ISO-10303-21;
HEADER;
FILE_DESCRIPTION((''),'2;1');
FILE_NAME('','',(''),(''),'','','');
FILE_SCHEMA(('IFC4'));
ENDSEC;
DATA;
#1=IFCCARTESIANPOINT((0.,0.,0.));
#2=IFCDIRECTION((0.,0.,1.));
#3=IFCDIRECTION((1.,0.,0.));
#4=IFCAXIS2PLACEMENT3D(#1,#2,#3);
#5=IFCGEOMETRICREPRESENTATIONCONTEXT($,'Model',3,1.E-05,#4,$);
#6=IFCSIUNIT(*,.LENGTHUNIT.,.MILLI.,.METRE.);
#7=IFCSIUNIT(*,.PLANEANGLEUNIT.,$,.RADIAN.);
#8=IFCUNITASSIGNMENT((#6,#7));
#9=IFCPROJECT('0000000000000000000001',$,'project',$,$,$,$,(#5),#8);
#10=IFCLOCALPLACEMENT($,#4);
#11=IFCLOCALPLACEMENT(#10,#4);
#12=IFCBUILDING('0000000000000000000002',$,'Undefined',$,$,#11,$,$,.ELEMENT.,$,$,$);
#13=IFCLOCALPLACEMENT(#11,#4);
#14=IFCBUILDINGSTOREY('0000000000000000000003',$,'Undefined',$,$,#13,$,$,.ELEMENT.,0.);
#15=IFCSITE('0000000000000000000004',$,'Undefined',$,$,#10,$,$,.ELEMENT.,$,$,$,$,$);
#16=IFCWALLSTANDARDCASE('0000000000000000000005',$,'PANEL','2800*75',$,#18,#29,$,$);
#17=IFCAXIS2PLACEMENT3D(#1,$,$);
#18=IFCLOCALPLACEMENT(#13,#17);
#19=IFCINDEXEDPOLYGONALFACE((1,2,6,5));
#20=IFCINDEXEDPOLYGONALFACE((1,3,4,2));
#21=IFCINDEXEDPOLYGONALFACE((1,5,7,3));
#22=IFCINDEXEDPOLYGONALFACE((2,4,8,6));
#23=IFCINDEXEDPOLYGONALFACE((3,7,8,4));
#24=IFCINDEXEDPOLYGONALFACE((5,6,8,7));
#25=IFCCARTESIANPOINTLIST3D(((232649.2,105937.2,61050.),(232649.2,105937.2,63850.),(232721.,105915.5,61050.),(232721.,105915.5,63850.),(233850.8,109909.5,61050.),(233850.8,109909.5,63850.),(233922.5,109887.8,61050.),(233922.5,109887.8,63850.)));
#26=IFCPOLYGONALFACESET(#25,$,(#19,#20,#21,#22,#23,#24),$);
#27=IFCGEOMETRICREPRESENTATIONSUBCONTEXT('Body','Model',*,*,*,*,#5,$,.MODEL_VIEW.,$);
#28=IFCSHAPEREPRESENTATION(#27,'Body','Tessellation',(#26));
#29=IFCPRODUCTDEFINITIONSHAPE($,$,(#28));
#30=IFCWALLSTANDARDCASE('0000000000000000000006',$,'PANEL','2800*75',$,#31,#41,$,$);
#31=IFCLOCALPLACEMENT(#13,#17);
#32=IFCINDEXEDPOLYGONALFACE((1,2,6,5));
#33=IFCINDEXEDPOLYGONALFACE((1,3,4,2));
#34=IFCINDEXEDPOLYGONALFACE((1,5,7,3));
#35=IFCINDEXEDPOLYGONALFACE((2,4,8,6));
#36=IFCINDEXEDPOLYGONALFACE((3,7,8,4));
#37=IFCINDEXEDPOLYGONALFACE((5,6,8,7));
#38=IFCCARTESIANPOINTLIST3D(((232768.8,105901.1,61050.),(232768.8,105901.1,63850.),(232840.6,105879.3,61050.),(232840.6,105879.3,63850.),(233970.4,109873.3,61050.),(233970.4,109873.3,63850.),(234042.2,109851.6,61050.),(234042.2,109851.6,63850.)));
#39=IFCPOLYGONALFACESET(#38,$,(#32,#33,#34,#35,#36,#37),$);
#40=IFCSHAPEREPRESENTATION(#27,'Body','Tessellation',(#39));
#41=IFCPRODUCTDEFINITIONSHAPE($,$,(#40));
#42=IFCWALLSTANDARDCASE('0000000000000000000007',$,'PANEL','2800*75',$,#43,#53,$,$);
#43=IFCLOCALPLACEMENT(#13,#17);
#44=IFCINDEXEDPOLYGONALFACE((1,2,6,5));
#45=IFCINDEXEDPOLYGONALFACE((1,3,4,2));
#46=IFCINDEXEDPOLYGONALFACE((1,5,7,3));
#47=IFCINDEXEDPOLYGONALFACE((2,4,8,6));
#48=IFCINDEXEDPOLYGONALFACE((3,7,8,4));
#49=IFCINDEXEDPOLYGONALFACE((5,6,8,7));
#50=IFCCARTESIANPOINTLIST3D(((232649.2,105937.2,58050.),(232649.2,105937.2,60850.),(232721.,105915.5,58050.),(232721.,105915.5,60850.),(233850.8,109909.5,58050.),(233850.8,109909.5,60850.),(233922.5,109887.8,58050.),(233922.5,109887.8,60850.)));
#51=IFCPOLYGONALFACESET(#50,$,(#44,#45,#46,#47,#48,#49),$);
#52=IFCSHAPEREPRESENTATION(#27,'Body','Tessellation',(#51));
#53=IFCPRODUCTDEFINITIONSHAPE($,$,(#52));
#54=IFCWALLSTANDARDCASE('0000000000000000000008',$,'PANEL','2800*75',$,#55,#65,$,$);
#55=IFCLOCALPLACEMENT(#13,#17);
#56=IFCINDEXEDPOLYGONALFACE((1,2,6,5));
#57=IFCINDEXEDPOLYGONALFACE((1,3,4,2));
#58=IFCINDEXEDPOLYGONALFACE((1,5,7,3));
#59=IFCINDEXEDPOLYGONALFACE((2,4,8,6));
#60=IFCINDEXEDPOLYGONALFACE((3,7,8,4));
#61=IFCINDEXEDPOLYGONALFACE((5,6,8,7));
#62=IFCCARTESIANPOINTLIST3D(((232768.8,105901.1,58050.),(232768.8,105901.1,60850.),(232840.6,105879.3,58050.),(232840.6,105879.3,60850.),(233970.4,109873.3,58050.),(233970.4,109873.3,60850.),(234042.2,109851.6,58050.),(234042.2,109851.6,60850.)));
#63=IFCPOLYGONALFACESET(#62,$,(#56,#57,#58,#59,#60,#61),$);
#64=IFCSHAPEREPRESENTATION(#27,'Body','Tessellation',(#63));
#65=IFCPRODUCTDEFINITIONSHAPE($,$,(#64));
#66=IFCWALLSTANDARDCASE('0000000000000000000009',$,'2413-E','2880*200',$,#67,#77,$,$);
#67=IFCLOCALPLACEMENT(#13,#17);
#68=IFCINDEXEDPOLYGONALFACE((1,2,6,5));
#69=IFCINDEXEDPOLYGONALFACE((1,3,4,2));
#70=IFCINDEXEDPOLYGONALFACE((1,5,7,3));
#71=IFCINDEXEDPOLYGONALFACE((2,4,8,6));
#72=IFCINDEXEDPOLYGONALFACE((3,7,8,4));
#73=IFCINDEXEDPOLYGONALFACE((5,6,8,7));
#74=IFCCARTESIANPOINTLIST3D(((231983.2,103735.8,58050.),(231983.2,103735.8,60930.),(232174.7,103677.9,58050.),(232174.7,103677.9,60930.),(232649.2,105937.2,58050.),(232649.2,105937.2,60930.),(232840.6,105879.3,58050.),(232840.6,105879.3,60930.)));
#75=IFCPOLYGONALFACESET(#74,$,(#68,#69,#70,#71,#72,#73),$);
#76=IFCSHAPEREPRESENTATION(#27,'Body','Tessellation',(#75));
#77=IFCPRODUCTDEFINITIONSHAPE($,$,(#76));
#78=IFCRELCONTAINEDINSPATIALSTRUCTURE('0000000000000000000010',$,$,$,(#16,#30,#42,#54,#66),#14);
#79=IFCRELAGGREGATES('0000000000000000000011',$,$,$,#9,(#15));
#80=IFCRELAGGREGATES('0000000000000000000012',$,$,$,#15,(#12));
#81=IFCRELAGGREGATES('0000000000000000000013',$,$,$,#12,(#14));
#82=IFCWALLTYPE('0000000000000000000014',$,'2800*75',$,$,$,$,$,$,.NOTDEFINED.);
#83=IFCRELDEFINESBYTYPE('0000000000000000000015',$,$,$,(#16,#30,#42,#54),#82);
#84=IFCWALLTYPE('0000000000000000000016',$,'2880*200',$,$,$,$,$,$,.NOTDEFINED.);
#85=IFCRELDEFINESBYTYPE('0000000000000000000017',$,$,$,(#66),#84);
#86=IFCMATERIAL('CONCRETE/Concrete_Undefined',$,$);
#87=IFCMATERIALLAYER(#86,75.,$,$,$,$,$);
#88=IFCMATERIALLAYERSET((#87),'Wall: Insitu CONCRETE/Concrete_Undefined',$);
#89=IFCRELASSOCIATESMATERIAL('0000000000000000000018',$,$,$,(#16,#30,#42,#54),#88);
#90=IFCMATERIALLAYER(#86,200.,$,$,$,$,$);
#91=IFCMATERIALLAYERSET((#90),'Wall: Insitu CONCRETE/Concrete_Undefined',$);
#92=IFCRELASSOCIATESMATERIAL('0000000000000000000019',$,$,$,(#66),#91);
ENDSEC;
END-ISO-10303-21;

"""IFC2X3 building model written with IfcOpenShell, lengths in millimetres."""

from ifc_helpers import new_model, si_unit, frame, frame_2d, origin_with_axes, place, context, subcontext, project, spatial, rectangle, extrude, material, layer, layer_set, layer_usage, type_object, element, save


model = new_model("IFC2X3")

# Units and contexts
model_context = context("Model", 3, precision=1e-05, world=origin_with_axes())
body_context = subcontext(model_context, "Body", "Model", "MODEL_VIEW")
ifc_project = project(units=[si_unit("LENGTHUNIT", "METRE", prefix="MILLI"), si_unit("PLANEANGLEUNIT", "RADIAN")], contexts=[model_context])

# Site, building, storey
site_placement = place(None, origin_with_axes())
site = spatial("IfcSite", under=ifc_project, at=site_placement, Name="Undefined", CompositionType="ELEMENT")
building_placement = place(site_placement, origin_with_axes())
building = spatial("IfcBuilding", under=site, at=building_placement, Name="Undefined", CompositionType="ELEMENT")
storey_placement = place(building_placement, origin_with_axes())
storey = spatial("IfcBuildingStorey", under=building, at=storey_placement, Name="Undefined", CompositionType="ELEMENT", Elevation=0.0)

# Walls
ifc_material_1 = material(Name="CONCRETE/Concrete_Undefined")
ifc_layer_1 = layer(ifc_material_1, 200.0)
ifc_layer_set_1 = layer_set([ifc_layer_1], Name="Wall: Insitu CONCRETE/Concrete_Undefined")
ifc_layer_2 = layer(ifc_material_1, 75.0)
ifc_layer_set_2 = layer_set([ifc_layer_2], Name="Wall: Insitu CONCRETE/Concrete_Undefined")
ifc_layer_usage_1 = layer_usage(ifc_layer_set_2, "AXIS2", "POSITIVE", -37.5)
wall_type_1 = type_object("IfcWallType", Name="2800*75", PredefinedType="NOTDEFINED")
wall_1_placement = place(storey_placement, frame((232685.1, 105926.4, 61050.0), z_axis=(0.0, 0.0, 1.0), x_axis=(0.289539, 0.957166, 0.0)))
element("IfcWallStandardCase", 1, at=wall_1_placement, inside=storey, type_object=wall_type_1, material=ifc_layer_usage_1, Name="PANEL", Description="2800*75", context=body_context, shape_type="SweptSolid", body=[
    extrude(rectangle(XDim=4150.0, YDim=75.0, at=frame_2d((0.0, 2075.0), x_axis=(0.0, -1.0))), frame((0.0, 0.0, 0.0), z_axis=(0.0, 0.0, 1.0), x_axis=(0.0, -1.0, 0.0)), (0.0, 0.0, 1.0), 2800.0),
])
ifc_layer_usage_2 = layer_usage(ifc_layer_set_2, "AXIS2", "POSITIVE", -37.5)
wall_2_placement = place(storey_placement, frame((232804.7, 105890.2, 61050.0), z_axis=(0.0, 0.0, 1.0), x_axis=(0.289539, 0.957166, 0.0)))
element("IfcWallStandardCase", 2, at=wall_2_placement, inside=storey, type_object=wall_type_1, material=ifc_layer_usage_2, Name="PANEL", Description="2800*75", context=body_context, shape_type="SweptSolid", body=[
    extrude(rectangle(XDim=4150.0, YDim=75.0, at=frame_2d((0.0, 2075.0), x_axis=(0.0, -1.0))), frame((0.0, 0.0, 0.0), z_axis=(0.0, 0.0, 1.0), x_axis=(0.0, -1.0, 0.0)), (0.0, 0.0, 1.0), 2800.0),
])
ifc_layer_usage_3 = layer_usage(ifc_layer_set_2, "AXIS2", "POSITIVE", -37.5)
wall_3_placement = place(storey_placement, frame((232685.1, 105926.4, 58050.0), z_axis=(0.0, 0.0, 1.0), x_axis=(0.289539, 0.957166, 0.0)))
element("IfcWallStandardCase", 3, at=wall_3_placement, inside=storey, type_object=wall_type_1, material=ifc_layer_usage_3, Name="PANEL", Description="2800*75", context=body_context, shape_type="SweptSolid", body=[
    extrude(rectangle(XDim=4150.0, YDim=75.0, at=frame_2d((0.0, 2075.0), x_axis=(0.0, -1.0))), frame((0.0, 0.0, 0.0), z_axis=(0.0, 0.0, 1.0), x_axis=(0.0, -1.0, 0.0)), (0.0, 0.0, 1.0), 2800.0),
])
ifc_layer_usage_4 = layer_usage(ifc_layer_set_2, "AXIS2", "POSITIVE", -37.5)
wall_4_placement = place(storey_placement, frame((232804.7, 105890.2, 58050.0), z_axis=(0.0, 0.0, 1.0), x_axis=(0.289539, 0.957166, 0.0)))
element("IfcWallStandardCase", 4, at=wall_4_placement, inside=storey, type_object=wall_type_1, material=ifc_layer_usage_4, Name="PANEL", Description="2800*75", context=body_context, shape_type="SweptSolid", body=[
    extrude(rectangle(XDim=4150.0, YDim=75.0, at=frame_2d((0.0, 2075.0), x_axis=(0.0, -1.0))), frame((0.0, 0.0, 0.0), z_axis=(0.0, 0.0, 1.0), x_axis=(0.0, -1.0, 0.0)), (0.0, 0.0, 1.0), 2800.0),
])
ifc_layer_usage_5 = layer_usage(ifc_layer_set_1, "AXIS2", "POSITIVE", -100.0)
wall_type_2 = type_object("IfcWallType", Name="2880*200", PredefinedType="NOTDEFINED")
wall_5_placement = place(storey_placement, frame((232079.0, 103706.8, 58050.0), z_axis=(0.0, 0.0, 1.0), x_axis=(0.289536, 0.957167, 0.0)))
element("IfcWallStandardCase", 5, at=wall_5_placement, inside=storey, type_object=wall_type_2, material=ifc_layer_usage_5, Name="2413-E", Description="2880*200", context=body_context, shape_type="SweptSolid", body=[
    extrude(rectangle(XDim=2300.0, YDim=200.0, at=frame_2d((0.0, 1150.0), x_axis=(0.0, -1.0))), frame((0.0, 0.0, 0.0), z_axis=(0.0, 0.0, 1.0), x_axis=(0.0, -1.0, 0.0)), (0.0, 0.0, 1.0), 2880.0),
])

save(model, "model.ifc")
